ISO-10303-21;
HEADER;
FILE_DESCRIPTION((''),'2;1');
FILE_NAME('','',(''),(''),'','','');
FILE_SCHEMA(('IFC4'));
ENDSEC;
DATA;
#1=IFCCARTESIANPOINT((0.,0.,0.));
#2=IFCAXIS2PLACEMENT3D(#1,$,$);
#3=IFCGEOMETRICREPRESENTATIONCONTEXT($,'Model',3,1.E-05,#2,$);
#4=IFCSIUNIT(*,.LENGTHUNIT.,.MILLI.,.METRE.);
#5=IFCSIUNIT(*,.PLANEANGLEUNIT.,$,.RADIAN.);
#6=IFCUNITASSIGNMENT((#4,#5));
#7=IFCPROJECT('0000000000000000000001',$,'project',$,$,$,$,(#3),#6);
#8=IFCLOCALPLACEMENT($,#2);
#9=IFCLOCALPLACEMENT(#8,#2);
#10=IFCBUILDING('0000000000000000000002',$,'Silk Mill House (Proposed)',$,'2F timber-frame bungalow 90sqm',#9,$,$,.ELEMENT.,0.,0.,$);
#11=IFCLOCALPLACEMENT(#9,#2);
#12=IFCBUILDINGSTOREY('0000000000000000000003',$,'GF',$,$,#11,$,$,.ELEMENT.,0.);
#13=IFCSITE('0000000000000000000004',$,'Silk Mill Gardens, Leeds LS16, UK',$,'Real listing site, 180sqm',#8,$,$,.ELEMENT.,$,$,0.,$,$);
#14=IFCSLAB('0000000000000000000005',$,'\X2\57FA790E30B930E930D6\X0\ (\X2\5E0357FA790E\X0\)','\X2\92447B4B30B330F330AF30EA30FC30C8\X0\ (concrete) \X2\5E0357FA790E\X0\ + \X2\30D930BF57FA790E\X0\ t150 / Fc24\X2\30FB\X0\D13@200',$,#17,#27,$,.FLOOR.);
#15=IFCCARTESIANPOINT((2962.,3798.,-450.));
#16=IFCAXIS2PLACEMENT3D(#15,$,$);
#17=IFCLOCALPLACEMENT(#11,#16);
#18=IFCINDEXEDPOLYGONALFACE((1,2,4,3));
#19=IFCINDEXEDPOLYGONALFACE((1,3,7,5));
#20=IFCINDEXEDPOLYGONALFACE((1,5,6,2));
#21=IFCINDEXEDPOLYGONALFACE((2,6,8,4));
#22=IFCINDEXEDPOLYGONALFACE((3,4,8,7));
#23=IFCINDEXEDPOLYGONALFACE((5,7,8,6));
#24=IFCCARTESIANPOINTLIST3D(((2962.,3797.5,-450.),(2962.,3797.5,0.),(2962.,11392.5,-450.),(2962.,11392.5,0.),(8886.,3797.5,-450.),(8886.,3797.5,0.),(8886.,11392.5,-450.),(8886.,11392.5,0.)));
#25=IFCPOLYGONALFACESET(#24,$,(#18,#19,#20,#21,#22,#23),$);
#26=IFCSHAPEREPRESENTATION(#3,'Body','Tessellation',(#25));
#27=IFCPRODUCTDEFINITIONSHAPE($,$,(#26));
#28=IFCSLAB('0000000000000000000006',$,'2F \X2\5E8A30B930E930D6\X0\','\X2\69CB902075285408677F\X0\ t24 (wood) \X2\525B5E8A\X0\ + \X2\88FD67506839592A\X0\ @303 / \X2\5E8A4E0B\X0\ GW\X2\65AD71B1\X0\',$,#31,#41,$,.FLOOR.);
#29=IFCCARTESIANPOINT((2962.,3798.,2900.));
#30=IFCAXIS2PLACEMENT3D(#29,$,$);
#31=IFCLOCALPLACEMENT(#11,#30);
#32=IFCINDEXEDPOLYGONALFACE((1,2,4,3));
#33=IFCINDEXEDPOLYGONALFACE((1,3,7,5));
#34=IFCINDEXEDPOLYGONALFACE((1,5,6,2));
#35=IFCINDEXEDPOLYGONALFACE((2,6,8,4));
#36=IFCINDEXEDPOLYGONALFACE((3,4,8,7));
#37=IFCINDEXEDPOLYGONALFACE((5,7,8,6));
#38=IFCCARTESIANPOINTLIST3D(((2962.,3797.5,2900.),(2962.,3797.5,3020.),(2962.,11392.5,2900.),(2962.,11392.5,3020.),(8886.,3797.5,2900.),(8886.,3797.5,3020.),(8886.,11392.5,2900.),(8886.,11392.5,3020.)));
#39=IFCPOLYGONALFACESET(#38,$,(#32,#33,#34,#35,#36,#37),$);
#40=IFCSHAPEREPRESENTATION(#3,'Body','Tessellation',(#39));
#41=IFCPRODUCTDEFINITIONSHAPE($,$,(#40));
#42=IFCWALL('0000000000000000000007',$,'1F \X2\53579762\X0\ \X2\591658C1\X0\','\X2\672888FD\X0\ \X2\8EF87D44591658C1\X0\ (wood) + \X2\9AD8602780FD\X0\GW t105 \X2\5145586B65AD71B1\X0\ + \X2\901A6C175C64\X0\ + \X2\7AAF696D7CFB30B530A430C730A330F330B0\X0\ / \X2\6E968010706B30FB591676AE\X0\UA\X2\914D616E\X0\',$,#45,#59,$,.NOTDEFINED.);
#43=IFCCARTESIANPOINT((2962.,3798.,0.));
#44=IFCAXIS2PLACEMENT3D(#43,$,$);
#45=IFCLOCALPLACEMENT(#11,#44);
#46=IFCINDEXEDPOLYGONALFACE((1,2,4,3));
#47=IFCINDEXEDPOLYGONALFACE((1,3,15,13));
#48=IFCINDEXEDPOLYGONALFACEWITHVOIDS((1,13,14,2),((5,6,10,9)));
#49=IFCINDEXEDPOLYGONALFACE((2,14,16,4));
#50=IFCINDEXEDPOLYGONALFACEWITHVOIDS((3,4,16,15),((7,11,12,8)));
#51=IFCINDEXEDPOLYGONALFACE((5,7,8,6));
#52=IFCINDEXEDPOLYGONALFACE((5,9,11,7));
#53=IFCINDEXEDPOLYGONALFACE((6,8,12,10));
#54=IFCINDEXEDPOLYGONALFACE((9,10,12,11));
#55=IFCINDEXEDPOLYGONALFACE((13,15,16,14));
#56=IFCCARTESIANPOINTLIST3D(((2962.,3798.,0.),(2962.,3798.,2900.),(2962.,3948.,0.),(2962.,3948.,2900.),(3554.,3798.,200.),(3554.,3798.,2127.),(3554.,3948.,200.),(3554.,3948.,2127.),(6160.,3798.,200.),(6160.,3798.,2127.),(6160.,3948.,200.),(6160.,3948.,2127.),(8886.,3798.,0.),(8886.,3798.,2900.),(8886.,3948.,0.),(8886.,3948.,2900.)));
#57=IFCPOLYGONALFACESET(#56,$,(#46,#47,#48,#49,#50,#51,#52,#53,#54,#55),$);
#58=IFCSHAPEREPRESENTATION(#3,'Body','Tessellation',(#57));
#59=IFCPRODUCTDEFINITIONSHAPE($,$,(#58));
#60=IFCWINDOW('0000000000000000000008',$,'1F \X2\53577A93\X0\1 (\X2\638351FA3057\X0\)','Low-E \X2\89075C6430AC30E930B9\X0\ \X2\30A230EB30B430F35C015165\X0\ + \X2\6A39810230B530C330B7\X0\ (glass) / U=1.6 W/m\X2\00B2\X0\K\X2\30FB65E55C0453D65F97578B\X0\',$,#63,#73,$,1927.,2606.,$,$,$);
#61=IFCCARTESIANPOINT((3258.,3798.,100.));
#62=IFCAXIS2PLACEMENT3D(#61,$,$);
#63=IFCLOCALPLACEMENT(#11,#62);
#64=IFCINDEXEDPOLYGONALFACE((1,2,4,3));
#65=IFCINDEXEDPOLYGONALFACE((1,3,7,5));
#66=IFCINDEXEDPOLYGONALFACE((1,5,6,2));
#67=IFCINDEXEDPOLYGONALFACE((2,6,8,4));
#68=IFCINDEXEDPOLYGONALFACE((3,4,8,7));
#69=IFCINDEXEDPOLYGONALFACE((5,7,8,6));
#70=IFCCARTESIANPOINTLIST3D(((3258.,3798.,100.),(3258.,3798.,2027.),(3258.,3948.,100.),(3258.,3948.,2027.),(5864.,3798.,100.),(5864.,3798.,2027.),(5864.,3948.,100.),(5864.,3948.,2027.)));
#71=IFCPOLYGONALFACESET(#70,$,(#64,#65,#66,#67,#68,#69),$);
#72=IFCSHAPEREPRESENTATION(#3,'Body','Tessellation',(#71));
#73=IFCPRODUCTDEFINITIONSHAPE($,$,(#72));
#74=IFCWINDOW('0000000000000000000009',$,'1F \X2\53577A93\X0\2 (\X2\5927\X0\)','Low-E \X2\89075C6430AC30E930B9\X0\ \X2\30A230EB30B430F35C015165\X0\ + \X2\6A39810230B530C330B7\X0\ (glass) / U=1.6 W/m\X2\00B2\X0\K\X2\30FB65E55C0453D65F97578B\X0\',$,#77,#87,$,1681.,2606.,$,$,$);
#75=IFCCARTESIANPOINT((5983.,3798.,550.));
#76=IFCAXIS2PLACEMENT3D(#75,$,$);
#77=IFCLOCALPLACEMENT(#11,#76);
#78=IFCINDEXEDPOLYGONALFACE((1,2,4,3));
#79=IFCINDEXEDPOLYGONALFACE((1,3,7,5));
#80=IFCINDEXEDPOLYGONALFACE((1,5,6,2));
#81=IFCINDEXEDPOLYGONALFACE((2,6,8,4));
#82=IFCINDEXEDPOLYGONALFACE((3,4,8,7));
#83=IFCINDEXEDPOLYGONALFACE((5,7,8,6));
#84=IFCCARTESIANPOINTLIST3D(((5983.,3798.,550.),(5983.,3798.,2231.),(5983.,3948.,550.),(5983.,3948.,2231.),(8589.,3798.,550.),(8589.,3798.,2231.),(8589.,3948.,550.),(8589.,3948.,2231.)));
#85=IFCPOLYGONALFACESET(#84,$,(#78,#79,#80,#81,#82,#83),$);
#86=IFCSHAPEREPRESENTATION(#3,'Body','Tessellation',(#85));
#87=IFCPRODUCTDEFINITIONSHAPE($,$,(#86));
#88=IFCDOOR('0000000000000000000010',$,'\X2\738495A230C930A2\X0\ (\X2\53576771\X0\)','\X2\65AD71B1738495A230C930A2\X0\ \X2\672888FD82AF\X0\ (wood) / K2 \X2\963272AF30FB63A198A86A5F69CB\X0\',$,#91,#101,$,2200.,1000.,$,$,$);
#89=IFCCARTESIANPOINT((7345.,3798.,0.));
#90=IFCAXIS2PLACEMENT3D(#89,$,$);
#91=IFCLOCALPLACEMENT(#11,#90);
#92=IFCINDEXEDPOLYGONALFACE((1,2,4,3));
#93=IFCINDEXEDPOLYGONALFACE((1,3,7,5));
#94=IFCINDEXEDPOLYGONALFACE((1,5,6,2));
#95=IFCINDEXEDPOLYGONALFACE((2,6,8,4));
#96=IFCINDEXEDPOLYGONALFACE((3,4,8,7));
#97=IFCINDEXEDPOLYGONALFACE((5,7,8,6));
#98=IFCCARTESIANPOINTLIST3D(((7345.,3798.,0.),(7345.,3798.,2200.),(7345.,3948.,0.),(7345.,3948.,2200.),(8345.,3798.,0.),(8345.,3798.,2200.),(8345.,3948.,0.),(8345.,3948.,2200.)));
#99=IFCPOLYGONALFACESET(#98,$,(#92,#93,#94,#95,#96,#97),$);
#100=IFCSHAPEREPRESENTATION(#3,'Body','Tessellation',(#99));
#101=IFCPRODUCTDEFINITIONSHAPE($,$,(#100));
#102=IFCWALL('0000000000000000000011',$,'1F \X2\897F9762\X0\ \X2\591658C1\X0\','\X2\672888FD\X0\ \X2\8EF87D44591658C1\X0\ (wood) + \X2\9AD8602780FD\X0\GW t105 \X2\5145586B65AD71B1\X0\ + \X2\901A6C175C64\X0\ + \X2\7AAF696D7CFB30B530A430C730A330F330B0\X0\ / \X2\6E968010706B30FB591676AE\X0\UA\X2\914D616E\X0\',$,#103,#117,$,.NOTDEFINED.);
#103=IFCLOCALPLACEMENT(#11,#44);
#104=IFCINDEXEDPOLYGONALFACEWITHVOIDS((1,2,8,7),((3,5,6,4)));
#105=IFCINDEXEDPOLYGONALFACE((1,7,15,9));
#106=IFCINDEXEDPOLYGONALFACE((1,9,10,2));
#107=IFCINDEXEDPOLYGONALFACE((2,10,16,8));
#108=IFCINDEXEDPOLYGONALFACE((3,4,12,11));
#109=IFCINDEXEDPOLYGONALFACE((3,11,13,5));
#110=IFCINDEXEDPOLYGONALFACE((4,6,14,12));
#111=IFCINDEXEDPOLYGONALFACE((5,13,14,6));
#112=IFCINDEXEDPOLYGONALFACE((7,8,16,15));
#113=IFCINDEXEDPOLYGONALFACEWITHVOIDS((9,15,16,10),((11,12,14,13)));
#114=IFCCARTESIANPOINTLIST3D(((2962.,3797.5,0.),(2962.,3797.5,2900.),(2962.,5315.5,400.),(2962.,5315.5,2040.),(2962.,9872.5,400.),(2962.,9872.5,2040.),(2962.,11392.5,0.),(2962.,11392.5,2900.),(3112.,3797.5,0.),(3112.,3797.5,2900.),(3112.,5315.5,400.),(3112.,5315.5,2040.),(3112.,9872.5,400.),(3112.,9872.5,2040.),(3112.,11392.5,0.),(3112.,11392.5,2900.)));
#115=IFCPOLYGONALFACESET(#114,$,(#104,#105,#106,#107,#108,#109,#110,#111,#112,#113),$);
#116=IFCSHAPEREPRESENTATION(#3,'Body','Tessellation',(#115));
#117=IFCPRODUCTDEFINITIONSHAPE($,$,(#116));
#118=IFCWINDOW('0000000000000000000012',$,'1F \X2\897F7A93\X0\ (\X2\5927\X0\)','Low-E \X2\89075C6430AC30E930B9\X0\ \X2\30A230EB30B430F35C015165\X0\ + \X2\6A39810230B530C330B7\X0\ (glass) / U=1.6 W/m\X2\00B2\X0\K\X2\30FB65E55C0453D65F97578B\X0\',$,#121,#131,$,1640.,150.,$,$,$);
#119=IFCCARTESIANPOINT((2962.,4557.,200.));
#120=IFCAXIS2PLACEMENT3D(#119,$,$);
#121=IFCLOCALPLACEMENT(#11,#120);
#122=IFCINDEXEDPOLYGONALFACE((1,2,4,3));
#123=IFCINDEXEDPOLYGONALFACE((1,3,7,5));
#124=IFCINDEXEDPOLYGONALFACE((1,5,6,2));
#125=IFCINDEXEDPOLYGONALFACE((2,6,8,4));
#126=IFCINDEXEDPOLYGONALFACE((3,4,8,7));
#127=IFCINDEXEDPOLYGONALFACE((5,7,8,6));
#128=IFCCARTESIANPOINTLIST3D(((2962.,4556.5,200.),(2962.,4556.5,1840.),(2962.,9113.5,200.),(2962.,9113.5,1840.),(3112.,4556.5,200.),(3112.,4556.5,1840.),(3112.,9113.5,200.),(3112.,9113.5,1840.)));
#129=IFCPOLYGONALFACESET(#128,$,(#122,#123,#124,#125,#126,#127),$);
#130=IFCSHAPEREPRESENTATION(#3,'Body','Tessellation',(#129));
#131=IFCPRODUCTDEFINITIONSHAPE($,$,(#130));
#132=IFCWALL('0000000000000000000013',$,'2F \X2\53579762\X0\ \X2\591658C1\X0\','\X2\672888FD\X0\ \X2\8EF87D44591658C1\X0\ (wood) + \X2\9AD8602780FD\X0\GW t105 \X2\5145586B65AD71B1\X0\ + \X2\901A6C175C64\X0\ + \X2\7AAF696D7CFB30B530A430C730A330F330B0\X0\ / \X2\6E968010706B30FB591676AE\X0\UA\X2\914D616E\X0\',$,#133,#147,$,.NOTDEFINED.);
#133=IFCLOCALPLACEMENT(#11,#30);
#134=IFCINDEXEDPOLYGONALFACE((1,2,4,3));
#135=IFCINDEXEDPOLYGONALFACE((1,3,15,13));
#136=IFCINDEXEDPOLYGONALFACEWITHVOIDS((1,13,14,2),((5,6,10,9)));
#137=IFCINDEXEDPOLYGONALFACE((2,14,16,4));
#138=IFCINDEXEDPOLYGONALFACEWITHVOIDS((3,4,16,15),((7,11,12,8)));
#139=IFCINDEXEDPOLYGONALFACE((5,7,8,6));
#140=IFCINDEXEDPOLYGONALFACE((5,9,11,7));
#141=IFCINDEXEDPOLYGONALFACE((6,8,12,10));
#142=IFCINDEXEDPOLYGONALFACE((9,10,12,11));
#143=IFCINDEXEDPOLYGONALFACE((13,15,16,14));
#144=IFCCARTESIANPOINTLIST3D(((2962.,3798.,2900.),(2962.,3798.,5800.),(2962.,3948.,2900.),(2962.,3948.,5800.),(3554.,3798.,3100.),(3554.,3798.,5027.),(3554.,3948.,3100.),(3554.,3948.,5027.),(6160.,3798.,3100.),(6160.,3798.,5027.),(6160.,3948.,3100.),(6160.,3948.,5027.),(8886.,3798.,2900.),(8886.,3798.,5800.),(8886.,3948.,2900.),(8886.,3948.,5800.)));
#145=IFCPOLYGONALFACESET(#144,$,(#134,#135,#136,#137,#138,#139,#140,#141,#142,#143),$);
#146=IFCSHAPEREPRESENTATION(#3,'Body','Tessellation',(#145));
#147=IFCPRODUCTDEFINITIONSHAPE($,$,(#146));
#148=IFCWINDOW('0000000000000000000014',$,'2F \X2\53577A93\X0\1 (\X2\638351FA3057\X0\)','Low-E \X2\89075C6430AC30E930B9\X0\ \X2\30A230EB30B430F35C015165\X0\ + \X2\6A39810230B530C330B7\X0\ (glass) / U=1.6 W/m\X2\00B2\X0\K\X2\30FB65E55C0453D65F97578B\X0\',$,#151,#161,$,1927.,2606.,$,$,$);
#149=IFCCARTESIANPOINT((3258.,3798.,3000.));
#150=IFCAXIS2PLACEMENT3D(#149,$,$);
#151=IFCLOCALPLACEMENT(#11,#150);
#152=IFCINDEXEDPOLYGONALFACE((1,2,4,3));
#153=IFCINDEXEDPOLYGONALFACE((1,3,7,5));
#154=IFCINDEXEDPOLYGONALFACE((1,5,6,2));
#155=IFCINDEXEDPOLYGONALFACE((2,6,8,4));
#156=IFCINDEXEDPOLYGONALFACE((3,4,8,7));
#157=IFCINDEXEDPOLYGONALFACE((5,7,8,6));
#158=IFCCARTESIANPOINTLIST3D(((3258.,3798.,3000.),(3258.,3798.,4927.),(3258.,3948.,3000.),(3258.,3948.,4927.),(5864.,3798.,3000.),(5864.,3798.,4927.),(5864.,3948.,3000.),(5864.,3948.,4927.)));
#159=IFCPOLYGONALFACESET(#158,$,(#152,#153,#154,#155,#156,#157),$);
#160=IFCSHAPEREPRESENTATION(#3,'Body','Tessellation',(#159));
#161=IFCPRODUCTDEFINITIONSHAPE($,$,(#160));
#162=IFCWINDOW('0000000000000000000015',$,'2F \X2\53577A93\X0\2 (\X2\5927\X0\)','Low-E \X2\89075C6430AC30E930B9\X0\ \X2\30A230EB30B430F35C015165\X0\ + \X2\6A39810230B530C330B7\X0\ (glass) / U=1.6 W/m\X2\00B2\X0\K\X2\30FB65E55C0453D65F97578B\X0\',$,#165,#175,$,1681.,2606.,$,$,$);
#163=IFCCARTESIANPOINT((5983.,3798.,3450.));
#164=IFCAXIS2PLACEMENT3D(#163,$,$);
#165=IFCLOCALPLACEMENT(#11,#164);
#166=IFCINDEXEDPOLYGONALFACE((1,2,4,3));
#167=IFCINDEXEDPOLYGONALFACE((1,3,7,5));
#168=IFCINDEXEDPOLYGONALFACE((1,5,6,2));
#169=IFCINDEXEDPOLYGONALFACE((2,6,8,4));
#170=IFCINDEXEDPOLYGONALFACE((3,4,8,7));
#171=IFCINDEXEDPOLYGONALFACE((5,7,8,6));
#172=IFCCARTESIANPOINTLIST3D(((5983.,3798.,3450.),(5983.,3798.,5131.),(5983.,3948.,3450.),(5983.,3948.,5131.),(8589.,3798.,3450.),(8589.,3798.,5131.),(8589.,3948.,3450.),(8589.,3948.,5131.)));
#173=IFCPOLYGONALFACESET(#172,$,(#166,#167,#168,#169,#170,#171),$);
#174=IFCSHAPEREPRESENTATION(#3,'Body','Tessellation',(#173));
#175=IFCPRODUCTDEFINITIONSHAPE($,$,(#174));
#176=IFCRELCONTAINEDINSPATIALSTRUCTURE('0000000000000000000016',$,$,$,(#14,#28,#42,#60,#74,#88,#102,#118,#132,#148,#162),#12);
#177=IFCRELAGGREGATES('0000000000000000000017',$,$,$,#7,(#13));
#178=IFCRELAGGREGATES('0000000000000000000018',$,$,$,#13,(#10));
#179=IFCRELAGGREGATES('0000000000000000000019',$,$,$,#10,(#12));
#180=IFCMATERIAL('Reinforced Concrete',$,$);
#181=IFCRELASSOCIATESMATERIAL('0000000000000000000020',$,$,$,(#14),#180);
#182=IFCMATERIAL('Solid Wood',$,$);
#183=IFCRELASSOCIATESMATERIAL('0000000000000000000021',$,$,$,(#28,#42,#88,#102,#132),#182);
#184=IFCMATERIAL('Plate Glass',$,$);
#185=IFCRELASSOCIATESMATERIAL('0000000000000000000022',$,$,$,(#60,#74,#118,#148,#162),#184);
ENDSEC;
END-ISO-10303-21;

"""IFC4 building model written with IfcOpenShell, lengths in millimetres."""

from ifc_helpers import new_model, si_unit, frame, frame_2d, origin, place, context, project, spatial, rectangle, extrude, material, element, fill, save


model = new_model("IFC4")

# Units and contexts
model_context = context("Model", 3, precision=1e-05, world=origin())
ifc_project = project(units=[si_unit("LENGTHUNIT", "METRE", prefix="MILLI"), si_unit("PLANEANGLEUNIT", "RADIAN")], contexts=[model_context])

# Site, building, storey
site_placement = place(None, origin())
site = spatial("IfcSite", under=ifc_project, at=site_placement, Name="Silk Mill Gardens, Leeds LS16, UK", ObjectType="Real listing site, 180sqm", CompositionType="ELEMENT", RefElevation=0.0)
building_placement = place(site_placement, origin())
building = spatial("IfcBuilding", under=site, at=building_placement, Name="Silk Mill House (Proposed)", ObjectType="2F timber-frame bungalow 90sqm", CompositionType="ELEMENT", ElevationOfRefHeight=0.0, ElevationOfTerrain=0.0)
storey_placement = place(building_placement, origin())
storey = spatial("IfcBuildingStorey", under=building, at=storey_placement, Name="GF", CompositionType="ELEMENT", Elevation=0.0)

# Slabs
ifc_material_1 = material(Name="Reinforced Concrete")
slab_1_placement = place(storey_placement, frame((2962.0, 3798.0, -450.0)))
element("IfcSlab", 1, at=slab_1_placement, inside=storey, material=ifc_material_1, Name="基礎スラブ (布基礎)", Description="鉄筋コンクリート (concrete) 布基礎 + ベタ基礎 t150 / Fc24・D13@200", PredefinedType="FLOOR", context=model_context, shape_type="SweptSolid", body=[
    extrude(rectangle(XDim=5924.0, YDim=7595.0, at=frame_2d((2962.0, 3797.0))), frame((2962.0, 3798.0, -450.0)), (0.0, 0.0, 1.0), 450.0),
])
ifc_material_2 = material(Name="Solid Wood")
slab_2_placement = place(storey_placement, frame((2962.0, 3798.0, 2900.0)))
element("IfcSlab", 2, at=slab_2_placement, inside=storey, material=ifc_material_2, Name="2F 床スラブ", Description="構造用合板 t24 (wood) 剛床 + 製材根太 @303 / 床下 GW断熱", PredefinedType="FLOOR", context=model_context, shape_type="SweptSolid", body=[
    extrude(rectangle(XDim=5924.0, YDim=7595.0, at=frame_2d((2962.0, 3797.0))), frame((2962.0, 3798.0, 2900.0)), (0.0, 0.0, 1.0), 120.0),
])

# Wall, openings, windows, door
wall_1_placement = place(storey_placement, frame((2962.0, 3798.0, 0.0)))
wall_1 = element("IfcWall", 3, at=wall_1_placement, inside=storey, material=ifc_material_2, Name="1F 南面 外壁", Description="木製 軸組外壁 (wood) + 高性能GW t105 充填断熱 + 通気層 + 窯業系サイディング / 準耐火・外皮UA配慮", PredefinedType="NOTDEFINED", context=model_context, shape_type="SweptSolid", body=[
    extrude(rectangle(XDim=5924.0, YDim=150.0, at=frame_2d((2962.0, 75.0))), frame((2962.0, 3798.0, 0.0)), (0.0, 0.0, 1.0), 2900.0),
])
opening_1_placement = place(storey_placement, frame((3258.0, 3798.0, 100.0)))
opening_1 = element("IfcOpeningElement", 4, at=opening_1_placement, cuts=wall_1, PredefinedType="NOTDEFINED", context=model_context, shape_type="SweptSolid", body=[
    extrude(rectangle(XDim=2606.0, YDim=150.0, at=frame_2d((1303.0, 75.0))), frame((3258.0, 3798.0, 100.0)), (0.0, 0.0, 1.0), 1927.0),
])
opening_2_placement = place(storey_placement, frame((5983.0, 3798.0, 550.0)))
opening_2 = element("IfcOpeningElement", 5, at=opening_2_placement, cuts=wall_1, PredefinedType="NOTDEFINED", context=model_context, shape_type="SweptSolid", body=[
    extrude(rectangle(XDim=2606.0, YDim=150.0, at=frame_2d((1303.0, 75.0))), frame((5983.0, 3798.0, 550.0)), (0.0, 0.0, 1.0), 1681.0),
])
opening_3_placement = place(storey_placement, frame((7345.0, 3798.0, 0.0)))
opening_3 = element("IfcOpeningElement", 6, at=opening_3_placement, cuts=wall_1, PredefinedType="NOTDEFINED", context=model_context, shape_type="SweptSolid", body=[
    extrude(rectangle(XDim=1000.0, YDim=150.0, at=frame_2d((500.0, 75.0))), frame((7345.0, 3798.0, 0.0)), (0.0, 0.0, 1.0), 2200.0),
])
ifc_material_3 = material(Name="Plate Glass")
window_1_placement = place(storey_placement, frame((3258.0, 3798.0, 100.0)))
window_1 = element("IfcWindow", 7, at=window_1_placement, inside=storey, material=ifc_material_3, Name="1F 南窓1 (掃出し)", Description="Low-E 複層ガラス アルゴン封入 + 樹脂サッシ (glass) / U=1.6 W/m²K・日射取得型", OverallHeight=1927.0, OverallWidth=2606.0, context=model_context, shape_type="SweptSolid", body=[
    extrude(rectangle(XDim=2606.0, YDim=150.0, at=frame_2d((1303.0, 75.0))), frame((3258.0, 3798.0, 100.0)), (0.0, 0.0, 1.0), 1927.0),
])
fill(opening_1, window_1)
window_2_placement = place(storey_placement, frame((5983.0, 3798.0, 550.0)))
window_2 = element("IfcWindow", 8, at=window_2_placement, inside=storey, material=ifc_material_3, Name="1F 南窓2 (大)", Description="Low-E 複層ガラス アルゴン封入 + 樹脂サッシ (glass) / U=1.6 W/m²K・日射取得型", OverallHeight=1681.0, OverallWidth=2606.0, context=model_context, shape_type="SweptSolid", body=[
    extrude(rectangle(XDim=2606.0, YDim=150.0, at=frame_2d((1303.0, 75.0))), frame((5983.0, 3798.0, 550.0)), (0.0, 0.0, 1.0), 1681.0),
])
fill(opening_2, window_2)
door_placement = place(storey_placement, frame((7345.0, 3798.0, 0.0)))
door = element("IfcDoor", 9, at=door_placement, inside=storey, material=ifc_material_2, Name="玄関ドア (南東)", Description="断熱玄関ドア 木製芯 (wood) / K2 防犯・採風機構", OverallHeight=2200.0, OverallWidth=1000.0, context=model_context, shape_type="SweptSolid", body=[
    extrude(rectangle(XDim=1000.0, YDim=150.0, at=frame_2d((500.0, 75.0))), frame((7345.0, 3798.0, 0.0)), (0.0, 0.0, 1.0), 2200.0),
])
fill(opening_3, door)

# Wall, opening, window
wall_2_placement = place(storey_placement, frame((2962.0, 3798.0, 0.0)))
wall_2 = element("IfcWall", 10, at=wall_2_placement, inside=storey, material=ifc_material_2, Name="1F 西面 外壁", Description="木製 軸組外壁 (wood) + 高性能GW t105 充填断熱 + 通気層 + 窯業系サイディング / 準耐火・外皮UA配慮", PredefinedType="NOTDEFINED", context=model_context, shape_type="SweptSolid", body=[
    extrude(rectangle(XDim=150.0, YDim=7595.0, at=frame_2d((75.0, 3797.0))), frame((2962.0, 3798.0, 0.0)), (0.0, 0.0, 1.0), 2900.0),
])
opening_4_placement = place(storey_placement, frame((2962.0, 4557.0, 200.0)))
opening_4 = element("IfcOpeningElement", 11, at=opening_4_placement, cuts=wall_2, PredefinedType="NOTDEFINED", context=model_context, shape_type="SweptSolid", body=[
    extrude(rectangle(XDim=150.0, YDim=4557.0, at=frame_2d((75.0, 2278.0))), frame((2962.0, 4557.0, 200.0)), (0.0, 0.0, 1.0), 1640.0),
])
window_3_placement = place(storey_placement, frame((2962.0, 4557.0, 200.0)))
window_3 = element("IfcWindow", 12, at=window_3_placement, inside=storey, material=ifc_material_3, Name="1F 西窓 (大)", Description="Low-E 複層ガラス アルゴン封入 + 樹脂サッシ (glass) / U=1.6 W/m²K・日射取得型", OverallHeight=1640.0, OverallWidth=150.0, context=model_context, shape_type="SweptSolid", body=[
    extrude(rectangle(XDim=150.0, YDim=4557.0, at=frame_2d((75.0, 2278.0))), frame((2962.0, 4557.0, 200.0)), (0.0, 0.0, 1.0), 1640.0),
])
fill(opening_4, window_3)

# Wall, openings, windows
wall_3_placement = place(storey_placement, frame((2962.0, 3798.0, 2900.0)))
wall_3 = element("IfcWall", 13, at=wall_3_placement, inside=storey, material=ifc_material_2, Name="2F 南面 外壁", Description="木製 軸組外壁 (wood) + 高性能GW t105 充填断熱 + 通気層 + 窯業系サイディング / 準耐火・外皮UA配慮", PredefinedType="NOTDEFINED", context=model_context, shape_type="SweptSolid", body=[
    extrude(rectangle(XDim=5924.0, YDim=150.0, at=frame_2d((2962.0, 75.0))), frame((2962.0, 3798.0, 2900.0)), (0.0, 0.0, 1.0), 2900.0),
])
opening_5_placement = place(storey_placement, frame((3258.0, 3798.0, 3000.0)))
opening_5 = element("IfcOpeningElement", 14, at=opening_5_placement, cuts=wall_3, PredefinedType="NOTDEFINED", context=model_context, shape_type="SweptSolid", body=[
    extrude(rectangle(XDim=2606.0, YDim=150.0, at=frame_2d((1303.0, 75.0))), frame((3258.0, 3798.0, 3000.0)), (0.0, 0.0, 1.0), 1927.0),
])
opening_6_placement = place(storey_placement, frame((5983.0, 3798.0, 3450.0)))
opening_6 = element("IfcOpeningElement", 15, at=opening_6_placement, cuts=wall_3, PredefinedType="NOTDEFINED", context=model_context, shape_type="SweptSolid", body=[
    extrude(rectangle(XDim=2606.0, YDim=150.0, at=frame_2d((1303.0, 75.0))), frame((5983.0, 3798.0, 3450.0)), (0.0, 0.0, 1.0), 1681.0),
])
window_4_placement = place(storey_placement, frame((3258.0, 3798.0, 3000.0)))
window_4 = element("IfcWindow", 16, at=window_4_placement, inside=storey, material=ifc_material_3, Name="2F 南窓1 (掃出し)", Description="Low-E 複層ガラス アルゴン封入 + 樹脂サッシ (glass) / U=1.6 W/m²K・日射取得型", OverallHeight=1927.0, OverallWidth=2606.0, context=model_context, shape_type="SweptSolid", body=[
    extrude(rectangle(XDim=2606.0, YDim=150.0, at=frame_2d((1303.0, 75.0))), frame((3258.0, 3798.0, 3000.0)), (0.0, 0.0, 1.0), 1927.0),
])
fill(opening_5, window_4)
window_5_placement = place(storey_placement, frame((5983.0, 3798.0, 3450.0)))
window_5 = element("IfcWindow", 17, at=window_5_placement, inside=storey, material=ifc_material_3, Name="2F 南窓2 (大)", Description="Low-E 複層ガラス アルゴン封入 + 樹脂サッシ (glass) / U=1.6 W/m²K・日射取得型", OverallHeight=1681.0, OverallWidth=2606.0, context=model_context, shape_type="SweptSolid", body=[
    extrude(rectangle(XDim=2606.0, YDim=150.0, at=frame_2d((1303.0, 75.0))), frame((5983.0, 3798.0, 3450.0)), (0.0, 0.0, 1.0), 1681.0),
])
fill(opening_6, window_5)

save(model, "model.ifc")
